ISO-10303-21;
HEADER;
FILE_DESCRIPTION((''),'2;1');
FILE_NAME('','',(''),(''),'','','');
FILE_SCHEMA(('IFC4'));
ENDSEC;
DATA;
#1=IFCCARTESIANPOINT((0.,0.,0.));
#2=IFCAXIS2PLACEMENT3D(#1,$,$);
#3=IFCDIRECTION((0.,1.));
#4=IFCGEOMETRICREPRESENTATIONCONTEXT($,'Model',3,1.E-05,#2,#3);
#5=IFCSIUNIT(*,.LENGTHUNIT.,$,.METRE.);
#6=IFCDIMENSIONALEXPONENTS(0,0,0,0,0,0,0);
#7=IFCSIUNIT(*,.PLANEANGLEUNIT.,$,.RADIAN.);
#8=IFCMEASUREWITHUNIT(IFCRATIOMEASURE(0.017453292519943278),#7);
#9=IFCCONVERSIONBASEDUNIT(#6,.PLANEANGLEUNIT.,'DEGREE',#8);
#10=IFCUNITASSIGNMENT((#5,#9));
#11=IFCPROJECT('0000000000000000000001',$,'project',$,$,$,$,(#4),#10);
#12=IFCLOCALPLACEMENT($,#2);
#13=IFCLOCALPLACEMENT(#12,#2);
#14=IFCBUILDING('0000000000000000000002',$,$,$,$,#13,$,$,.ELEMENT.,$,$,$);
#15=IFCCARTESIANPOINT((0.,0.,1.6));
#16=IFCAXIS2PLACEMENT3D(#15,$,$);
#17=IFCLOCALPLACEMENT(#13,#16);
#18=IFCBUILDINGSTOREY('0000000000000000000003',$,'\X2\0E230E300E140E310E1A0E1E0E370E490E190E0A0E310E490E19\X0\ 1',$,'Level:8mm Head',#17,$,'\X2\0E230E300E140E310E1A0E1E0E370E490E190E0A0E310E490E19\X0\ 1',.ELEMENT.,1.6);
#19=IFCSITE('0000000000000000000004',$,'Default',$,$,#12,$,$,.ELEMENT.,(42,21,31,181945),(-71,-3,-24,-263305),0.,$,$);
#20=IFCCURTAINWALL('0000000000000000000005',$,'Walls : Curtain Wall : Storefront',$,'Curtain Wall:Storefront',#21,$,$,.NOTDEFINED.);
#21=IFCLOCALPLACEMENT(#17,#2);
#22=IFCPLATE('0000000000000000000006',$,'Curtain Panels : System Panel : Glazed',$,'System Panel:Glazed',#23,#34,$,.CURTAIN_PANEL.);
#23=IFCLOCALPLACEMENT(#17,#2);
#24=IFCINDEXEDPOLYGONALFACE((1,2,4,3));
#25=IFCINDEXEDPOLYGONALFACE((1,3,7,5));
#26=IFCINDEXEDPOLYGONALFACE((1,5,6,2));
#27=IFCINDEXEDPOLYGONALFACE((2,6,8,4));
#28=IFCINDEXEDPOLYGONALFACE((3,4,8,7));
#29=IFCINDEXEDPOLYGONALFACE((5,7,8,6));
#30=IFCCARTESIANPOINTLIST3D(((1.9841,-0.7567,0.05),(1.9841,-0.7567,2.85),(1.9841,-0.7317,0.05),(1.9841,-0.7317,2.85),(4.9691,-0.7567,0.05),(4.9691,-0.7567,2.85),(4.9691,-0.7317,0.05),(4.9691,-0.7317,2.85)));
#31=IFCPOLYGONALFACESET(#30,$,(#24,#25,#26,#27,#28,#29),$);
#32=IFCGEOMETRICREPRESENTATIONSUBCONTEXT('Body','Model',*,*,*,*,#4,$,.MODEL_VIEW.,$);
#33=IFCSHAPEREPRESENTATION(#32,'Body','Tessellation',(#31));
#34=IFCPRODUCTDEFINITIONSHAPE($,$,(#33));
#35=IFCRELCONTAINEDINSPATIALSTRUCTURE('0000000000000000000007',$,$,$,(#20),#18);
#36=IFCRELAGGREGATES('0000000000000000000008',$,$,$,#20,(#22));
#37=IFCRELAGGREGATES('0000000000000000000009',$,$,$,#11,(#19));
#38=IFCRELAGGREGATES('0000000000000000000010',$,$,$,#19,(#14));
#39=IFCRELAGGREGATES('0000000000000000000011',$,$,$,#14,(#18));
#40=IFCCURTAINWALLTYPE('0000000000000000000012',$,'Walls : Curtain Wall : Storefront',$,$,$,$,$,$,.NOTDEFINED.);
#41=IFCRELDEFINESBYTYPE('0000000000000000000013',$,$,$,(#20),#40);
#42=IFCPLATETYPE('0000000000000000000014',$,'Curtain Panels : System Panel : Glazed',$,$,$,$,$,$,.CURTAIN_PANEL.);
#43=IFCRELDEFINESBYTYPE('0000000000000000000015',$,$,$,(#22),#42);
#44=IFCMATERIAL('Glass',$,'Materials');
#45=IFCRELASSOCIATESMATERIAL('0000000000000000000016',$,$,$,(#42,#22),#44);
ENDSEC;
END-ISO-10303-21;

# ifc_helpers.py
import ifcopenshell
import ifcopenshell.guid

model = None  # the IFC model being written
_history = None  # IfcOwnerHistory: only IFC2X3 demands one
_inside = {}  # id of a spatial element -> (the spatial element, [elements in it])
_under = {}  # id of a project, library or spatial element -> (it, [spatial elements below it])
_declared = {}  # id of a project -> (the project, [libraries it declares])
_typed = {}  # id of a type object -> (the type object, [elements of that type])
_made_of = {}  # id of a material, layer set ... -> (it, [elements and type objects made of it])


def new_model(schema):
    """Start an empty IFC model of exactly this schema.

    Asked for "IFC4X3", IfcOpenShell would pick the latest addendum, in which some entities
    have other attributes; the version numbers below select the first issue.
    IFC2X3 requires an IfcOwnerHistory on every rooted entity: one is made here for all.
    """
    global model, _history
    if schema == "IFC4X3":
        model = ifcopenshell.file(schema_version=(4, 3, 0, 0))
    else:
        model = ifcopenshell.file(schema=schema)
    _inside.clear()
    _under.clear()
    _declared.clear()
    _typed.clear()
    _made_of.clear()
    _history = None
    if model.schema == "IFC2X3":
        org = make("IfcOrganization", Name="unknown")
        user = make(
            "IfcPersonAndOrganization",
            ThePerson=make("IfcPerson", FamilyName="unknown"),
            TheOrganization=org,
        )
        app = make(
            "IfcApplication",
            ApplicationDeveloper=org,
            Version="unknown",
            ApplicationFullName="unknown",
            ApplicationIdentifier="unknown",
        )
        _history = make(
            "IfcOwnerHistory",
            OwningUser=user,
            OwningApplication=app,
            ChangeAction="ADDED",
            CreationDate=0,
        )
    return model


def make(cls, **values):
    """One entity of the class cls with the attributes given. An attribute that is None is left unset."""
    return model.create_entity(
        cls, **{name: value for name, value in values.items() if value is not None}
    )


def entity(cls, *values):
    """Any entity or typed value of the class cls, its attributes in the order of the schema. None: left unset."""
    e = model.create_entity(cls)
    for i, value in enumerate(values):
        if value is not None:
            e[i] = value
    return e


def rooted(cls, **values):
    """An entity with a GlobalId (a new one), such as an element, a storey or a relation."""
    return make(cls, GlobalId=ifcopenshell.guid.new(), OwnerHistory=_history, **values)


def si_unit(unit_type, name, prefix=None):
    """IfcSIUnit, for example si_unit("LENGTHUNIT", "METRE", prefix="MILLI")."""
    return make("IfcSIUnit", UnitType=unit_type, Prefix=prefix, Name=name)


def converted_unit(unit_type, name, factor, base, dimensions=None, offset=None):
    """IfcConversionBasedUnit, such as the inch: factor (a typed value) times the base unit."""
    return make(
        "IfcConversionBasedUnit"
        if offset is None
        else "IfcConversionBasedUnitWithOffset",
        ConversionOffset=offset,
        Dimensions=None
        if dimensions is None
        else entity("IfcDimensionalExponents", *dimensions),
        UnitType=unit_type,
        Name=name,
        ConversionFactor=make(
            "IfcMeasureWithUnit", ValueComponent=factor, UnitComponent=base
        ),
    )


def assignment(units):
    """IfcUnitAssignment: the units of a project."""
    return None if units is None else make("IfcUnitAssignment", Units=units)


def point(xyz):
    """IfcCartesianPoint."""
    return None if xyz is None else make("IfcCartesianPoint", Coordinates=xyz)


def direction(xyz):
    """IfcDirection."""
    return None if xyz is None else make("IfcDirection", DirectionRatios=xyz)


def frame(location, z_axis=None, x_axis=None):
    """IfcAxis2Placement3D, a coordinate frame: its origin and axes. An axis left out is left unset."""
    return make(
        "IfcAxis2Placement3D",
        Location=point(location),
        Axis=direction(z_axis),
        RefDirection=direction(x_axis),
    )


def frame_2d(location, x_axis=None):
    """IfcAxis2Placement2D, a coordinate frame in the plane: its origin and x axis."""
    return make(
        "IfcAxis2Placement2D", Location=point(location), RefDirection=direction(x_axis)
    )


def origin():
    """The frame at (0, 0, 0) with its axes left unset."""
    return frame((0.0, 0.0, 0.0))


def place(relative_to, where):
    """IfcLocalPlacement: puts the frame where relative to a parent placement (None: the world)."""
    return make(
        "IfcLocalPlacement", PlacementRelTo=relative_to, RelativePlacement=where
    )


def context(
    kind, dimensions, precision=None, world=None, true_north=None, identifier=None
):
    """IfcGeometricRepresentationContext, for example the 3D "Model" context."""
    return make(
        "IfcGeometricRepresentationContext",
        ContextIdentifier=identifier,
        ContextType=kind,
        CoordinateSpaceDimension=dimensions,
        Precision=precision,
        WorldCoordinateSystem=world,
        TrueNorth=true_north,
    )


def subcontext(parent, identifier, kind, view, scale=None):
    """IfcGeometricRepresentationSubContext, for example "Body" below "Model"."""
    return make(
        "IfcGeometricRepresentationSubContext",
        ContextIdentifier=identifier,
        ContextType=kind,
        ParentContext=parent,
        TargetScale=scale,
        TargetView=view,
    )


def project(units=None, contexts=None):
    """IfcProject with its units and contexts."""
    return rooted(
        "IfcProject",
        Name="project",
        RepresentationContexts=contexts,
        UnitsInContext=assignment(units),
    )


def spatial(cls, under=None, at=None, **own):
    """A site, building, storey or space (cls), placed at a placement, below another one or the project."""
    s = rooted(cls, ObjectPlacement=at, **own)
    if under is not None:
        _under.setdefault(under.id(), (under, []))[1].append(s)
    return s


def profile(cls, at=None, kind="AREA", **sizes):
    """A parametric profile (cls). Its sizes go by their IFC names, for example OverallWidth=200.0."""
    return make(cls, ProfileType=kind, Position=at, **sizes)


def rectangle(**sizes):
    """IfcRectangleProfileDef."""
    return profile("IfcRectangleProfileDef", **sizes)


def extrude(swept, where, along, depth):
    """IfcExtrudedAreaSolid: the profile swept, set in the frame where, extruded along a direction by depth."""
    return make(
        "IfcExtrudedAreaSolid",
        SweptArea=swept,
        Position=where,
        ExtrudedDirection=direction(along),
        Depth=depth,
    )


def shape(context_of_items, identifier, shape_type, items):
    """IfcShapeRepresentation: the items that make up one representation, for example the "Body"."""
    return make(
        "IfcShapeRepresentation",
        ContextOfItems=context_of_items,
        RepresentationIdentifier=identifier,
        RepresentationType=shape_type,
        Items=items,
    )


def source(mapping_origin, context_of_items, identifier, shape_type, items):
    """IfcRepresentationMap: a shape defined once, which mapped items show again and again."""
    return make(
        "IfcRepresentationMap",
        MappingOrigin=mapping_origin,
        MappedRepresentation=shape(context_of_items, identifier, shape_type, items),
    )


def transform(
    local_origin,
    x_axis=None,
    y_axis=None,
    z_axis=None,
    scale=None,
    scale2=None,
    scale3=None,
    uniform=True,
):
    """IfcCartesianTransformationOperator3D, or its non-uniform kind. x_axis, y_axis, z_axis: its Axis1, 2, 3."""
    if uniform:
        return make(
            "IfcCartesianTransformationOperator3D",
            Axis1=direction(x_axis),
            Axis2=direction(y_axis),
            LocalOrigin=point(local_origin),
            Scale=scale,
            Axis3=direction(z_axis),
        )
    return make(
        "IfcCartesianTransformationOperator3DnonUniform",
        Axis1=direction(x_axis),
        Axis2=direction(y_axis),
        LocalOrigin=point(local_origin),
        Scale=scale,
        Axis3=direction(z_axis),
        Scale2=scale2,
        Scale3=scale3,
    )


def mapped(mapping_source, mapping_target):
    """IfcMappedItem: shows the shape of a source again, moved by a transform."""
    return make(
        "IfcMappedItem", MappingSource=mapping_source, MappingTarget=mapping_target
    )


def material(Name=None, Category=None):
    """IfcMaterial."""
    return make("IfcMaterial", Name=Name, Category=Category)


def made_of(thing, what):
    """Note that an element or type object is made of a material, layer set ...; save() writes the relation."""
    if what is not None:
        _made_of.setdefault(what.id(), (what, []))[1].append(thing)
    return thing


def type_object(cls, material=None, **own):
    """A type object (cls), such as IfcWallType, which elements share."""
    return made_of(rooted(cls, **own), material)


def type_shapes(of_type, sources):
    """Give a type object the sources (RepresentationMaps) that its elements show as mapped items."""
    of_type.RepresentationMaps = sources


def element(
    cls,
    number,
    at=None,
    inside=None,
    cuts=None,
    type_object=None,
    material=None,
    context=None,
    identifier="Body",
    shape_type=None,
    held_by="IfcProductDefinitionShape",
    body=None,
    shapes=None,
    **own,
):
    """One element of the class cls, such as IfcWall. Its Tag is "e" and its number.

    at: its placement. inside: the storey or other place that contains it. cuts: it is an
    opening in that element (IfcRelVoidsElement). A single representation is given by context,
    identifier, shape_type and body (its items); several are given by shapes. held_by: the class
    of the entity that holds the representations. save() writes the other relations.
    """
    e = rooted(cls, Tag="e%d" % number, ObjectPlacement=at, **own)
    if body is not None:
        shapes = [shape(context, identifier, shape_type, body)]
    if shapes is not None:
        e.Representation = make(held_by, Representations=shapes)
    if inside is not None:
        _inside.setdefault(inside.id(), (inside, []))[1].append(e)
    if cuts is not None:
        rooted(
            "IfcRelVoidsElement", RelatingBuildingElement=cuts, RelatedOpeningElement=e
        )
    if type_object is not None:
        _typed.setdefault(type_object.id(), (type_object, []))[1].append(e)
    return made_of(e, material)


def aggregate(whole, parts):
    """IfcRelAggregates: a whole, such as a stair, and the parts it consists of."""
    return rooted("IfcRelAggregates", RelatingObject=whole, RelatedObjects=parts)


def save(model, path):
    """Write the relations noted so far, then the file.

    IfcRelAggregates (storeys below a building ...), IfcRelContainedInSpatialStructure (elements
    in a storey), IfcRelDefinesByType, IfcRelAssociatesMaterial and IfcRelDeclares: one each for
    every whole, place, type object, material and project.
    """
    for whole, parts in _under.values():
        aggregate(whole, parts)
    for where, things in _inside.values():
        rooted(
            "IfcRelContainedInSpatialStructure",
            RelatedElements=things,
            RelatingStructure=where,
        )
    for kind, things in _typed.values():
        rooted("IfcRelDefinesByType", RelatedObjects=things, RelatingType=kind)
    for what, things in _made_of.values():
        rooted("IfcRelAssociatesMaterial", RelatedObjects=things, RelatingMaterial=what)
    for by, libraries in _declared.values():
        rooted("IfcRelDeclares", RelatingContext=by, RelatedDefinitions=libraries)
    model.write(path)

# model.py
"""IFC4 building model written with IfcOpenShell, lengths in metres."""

from ifc_helpers import new_model, entity, si_unit, converted_unit, direction, frame, frame_2d, origin, place, context, subcontext, project, spatial, rectangle, extrude, source, transform, mapped, material, type_object, type_shapes, element, aggregate, save


model = new_model("IFC4")

# Units and contexts
model_context = context("Model", 3, precision=1e-05, world=origin(), true_north=direction((0.0, 1.0)))
body_context = subcontext(model_context, "Body", "Model", "MODEL_VIEW")
ifc_project = project(units=[si_unit("LENGTHUNIT", "METRE"), converted_unit("PLANEANGLEUNIT", "DEGREE", entity("IfcRatioMeasure", 0.017453292519943278), si_unit("PLANEANGLEUNIT", "RADIAN"), dimensions=[0, 0, 0, 0, 0, 0, 0])], contexts=[model_context])

# Site, building, storey
site_placement = place(None, origin())
site = spatial("IfcSite", under=ifc_project, at=site_placement, Name="Default", CompositionType="ELEMENT", RefLatitude=(42, 21, 31, 181945), RefLongitude=(-71, -3, -24, -263305), RefElevation=0.0)
building_placement = place(site_placement, origin())
building = spatial("IfcBuilding", under=site, at=building_placement, CompositionType="ELEMENT")
storey_placement = place(building_placement, frame((0.0, 0.0, 1.6)))
storey = spatial("IfcBuildingStorey", under=building, at=storey_placement, Name="ระดับพื้นชั้น 1", ObjectType="Level:8mm Head", LongName="ระดับพื้นชั้น 1", CompositionType="ELEMENT", Elevation=1.6)

# Shared definitions
curtain_wall_type = type_object("IfcCurtainWallType", Name="Walls : Curtain Wall : Storefront", PredefinedType="NOTDEFINED")

# Curtain wall
curtain_wall_1_placement = place(storey_placement, frame((0.0, 0.0, -1.6)))
curtain_wall_1 = element("IfcCurtainWall", 1, at=curtain_wall_1_placement, inside=storey, type_object=curtain_wall_type, Name="Walls : Curtain Wall : Storefront", ObjectType="Curtain Wall:Storefront", PredefinedType="NOTDEFINED")

# Plate
ifc_material_1 = material(Name="Glass", Category="Materials")
plate_type_1 = type_object("IfcPlateType", Name="Curtain Panels : System Panel : Glazed", PredefinedType="CURTAIN_PANEL", material=ifc_material_1)
shared_shape_1 = source(origin(), body_context, "Body", "SweptSolid", [
    extrude(rectangle(XDim=0.025, YDim=2.985, at=frame_2d((0.0, 0.0), x_axis=(1.0, 0.0))), frame((1.4925, 0.0125, 0.0), z_axis=(0.0, 0.0, 1.0), x_axis=(0.0, 1.0, 0.0)), (0.0, 0.0, 1.0), 2.8),
])
type_shapes(plate_type_1, [shared_shape_1])
plate_1_placement = place(curtain_wall_1_placement, frame((4.9691, -0.7317, 1.65), z_axis=(0.0, 0.0, 1.0), x_axis=(-1.0, 0.0, 0.0)))
plate_1 = element("IfcPlate", 2, at=plate_1_placement, type_object=plate_type_1, material=ifc_material_1, Name="Curtain Panels : System Panel : Glazed", ObjectType="System Panel:Glazed", PredefinedType="CURTAIN_PANEL", context=body_context, shape_type="MappedRepresentation", body=[
    mapped(shared_shape_1, transform((0.0, 0.0, 0.0), scale=1.0)),
])
aggregate(curtain_wall_1, [plate_1])

save(model, "model.ifc")
